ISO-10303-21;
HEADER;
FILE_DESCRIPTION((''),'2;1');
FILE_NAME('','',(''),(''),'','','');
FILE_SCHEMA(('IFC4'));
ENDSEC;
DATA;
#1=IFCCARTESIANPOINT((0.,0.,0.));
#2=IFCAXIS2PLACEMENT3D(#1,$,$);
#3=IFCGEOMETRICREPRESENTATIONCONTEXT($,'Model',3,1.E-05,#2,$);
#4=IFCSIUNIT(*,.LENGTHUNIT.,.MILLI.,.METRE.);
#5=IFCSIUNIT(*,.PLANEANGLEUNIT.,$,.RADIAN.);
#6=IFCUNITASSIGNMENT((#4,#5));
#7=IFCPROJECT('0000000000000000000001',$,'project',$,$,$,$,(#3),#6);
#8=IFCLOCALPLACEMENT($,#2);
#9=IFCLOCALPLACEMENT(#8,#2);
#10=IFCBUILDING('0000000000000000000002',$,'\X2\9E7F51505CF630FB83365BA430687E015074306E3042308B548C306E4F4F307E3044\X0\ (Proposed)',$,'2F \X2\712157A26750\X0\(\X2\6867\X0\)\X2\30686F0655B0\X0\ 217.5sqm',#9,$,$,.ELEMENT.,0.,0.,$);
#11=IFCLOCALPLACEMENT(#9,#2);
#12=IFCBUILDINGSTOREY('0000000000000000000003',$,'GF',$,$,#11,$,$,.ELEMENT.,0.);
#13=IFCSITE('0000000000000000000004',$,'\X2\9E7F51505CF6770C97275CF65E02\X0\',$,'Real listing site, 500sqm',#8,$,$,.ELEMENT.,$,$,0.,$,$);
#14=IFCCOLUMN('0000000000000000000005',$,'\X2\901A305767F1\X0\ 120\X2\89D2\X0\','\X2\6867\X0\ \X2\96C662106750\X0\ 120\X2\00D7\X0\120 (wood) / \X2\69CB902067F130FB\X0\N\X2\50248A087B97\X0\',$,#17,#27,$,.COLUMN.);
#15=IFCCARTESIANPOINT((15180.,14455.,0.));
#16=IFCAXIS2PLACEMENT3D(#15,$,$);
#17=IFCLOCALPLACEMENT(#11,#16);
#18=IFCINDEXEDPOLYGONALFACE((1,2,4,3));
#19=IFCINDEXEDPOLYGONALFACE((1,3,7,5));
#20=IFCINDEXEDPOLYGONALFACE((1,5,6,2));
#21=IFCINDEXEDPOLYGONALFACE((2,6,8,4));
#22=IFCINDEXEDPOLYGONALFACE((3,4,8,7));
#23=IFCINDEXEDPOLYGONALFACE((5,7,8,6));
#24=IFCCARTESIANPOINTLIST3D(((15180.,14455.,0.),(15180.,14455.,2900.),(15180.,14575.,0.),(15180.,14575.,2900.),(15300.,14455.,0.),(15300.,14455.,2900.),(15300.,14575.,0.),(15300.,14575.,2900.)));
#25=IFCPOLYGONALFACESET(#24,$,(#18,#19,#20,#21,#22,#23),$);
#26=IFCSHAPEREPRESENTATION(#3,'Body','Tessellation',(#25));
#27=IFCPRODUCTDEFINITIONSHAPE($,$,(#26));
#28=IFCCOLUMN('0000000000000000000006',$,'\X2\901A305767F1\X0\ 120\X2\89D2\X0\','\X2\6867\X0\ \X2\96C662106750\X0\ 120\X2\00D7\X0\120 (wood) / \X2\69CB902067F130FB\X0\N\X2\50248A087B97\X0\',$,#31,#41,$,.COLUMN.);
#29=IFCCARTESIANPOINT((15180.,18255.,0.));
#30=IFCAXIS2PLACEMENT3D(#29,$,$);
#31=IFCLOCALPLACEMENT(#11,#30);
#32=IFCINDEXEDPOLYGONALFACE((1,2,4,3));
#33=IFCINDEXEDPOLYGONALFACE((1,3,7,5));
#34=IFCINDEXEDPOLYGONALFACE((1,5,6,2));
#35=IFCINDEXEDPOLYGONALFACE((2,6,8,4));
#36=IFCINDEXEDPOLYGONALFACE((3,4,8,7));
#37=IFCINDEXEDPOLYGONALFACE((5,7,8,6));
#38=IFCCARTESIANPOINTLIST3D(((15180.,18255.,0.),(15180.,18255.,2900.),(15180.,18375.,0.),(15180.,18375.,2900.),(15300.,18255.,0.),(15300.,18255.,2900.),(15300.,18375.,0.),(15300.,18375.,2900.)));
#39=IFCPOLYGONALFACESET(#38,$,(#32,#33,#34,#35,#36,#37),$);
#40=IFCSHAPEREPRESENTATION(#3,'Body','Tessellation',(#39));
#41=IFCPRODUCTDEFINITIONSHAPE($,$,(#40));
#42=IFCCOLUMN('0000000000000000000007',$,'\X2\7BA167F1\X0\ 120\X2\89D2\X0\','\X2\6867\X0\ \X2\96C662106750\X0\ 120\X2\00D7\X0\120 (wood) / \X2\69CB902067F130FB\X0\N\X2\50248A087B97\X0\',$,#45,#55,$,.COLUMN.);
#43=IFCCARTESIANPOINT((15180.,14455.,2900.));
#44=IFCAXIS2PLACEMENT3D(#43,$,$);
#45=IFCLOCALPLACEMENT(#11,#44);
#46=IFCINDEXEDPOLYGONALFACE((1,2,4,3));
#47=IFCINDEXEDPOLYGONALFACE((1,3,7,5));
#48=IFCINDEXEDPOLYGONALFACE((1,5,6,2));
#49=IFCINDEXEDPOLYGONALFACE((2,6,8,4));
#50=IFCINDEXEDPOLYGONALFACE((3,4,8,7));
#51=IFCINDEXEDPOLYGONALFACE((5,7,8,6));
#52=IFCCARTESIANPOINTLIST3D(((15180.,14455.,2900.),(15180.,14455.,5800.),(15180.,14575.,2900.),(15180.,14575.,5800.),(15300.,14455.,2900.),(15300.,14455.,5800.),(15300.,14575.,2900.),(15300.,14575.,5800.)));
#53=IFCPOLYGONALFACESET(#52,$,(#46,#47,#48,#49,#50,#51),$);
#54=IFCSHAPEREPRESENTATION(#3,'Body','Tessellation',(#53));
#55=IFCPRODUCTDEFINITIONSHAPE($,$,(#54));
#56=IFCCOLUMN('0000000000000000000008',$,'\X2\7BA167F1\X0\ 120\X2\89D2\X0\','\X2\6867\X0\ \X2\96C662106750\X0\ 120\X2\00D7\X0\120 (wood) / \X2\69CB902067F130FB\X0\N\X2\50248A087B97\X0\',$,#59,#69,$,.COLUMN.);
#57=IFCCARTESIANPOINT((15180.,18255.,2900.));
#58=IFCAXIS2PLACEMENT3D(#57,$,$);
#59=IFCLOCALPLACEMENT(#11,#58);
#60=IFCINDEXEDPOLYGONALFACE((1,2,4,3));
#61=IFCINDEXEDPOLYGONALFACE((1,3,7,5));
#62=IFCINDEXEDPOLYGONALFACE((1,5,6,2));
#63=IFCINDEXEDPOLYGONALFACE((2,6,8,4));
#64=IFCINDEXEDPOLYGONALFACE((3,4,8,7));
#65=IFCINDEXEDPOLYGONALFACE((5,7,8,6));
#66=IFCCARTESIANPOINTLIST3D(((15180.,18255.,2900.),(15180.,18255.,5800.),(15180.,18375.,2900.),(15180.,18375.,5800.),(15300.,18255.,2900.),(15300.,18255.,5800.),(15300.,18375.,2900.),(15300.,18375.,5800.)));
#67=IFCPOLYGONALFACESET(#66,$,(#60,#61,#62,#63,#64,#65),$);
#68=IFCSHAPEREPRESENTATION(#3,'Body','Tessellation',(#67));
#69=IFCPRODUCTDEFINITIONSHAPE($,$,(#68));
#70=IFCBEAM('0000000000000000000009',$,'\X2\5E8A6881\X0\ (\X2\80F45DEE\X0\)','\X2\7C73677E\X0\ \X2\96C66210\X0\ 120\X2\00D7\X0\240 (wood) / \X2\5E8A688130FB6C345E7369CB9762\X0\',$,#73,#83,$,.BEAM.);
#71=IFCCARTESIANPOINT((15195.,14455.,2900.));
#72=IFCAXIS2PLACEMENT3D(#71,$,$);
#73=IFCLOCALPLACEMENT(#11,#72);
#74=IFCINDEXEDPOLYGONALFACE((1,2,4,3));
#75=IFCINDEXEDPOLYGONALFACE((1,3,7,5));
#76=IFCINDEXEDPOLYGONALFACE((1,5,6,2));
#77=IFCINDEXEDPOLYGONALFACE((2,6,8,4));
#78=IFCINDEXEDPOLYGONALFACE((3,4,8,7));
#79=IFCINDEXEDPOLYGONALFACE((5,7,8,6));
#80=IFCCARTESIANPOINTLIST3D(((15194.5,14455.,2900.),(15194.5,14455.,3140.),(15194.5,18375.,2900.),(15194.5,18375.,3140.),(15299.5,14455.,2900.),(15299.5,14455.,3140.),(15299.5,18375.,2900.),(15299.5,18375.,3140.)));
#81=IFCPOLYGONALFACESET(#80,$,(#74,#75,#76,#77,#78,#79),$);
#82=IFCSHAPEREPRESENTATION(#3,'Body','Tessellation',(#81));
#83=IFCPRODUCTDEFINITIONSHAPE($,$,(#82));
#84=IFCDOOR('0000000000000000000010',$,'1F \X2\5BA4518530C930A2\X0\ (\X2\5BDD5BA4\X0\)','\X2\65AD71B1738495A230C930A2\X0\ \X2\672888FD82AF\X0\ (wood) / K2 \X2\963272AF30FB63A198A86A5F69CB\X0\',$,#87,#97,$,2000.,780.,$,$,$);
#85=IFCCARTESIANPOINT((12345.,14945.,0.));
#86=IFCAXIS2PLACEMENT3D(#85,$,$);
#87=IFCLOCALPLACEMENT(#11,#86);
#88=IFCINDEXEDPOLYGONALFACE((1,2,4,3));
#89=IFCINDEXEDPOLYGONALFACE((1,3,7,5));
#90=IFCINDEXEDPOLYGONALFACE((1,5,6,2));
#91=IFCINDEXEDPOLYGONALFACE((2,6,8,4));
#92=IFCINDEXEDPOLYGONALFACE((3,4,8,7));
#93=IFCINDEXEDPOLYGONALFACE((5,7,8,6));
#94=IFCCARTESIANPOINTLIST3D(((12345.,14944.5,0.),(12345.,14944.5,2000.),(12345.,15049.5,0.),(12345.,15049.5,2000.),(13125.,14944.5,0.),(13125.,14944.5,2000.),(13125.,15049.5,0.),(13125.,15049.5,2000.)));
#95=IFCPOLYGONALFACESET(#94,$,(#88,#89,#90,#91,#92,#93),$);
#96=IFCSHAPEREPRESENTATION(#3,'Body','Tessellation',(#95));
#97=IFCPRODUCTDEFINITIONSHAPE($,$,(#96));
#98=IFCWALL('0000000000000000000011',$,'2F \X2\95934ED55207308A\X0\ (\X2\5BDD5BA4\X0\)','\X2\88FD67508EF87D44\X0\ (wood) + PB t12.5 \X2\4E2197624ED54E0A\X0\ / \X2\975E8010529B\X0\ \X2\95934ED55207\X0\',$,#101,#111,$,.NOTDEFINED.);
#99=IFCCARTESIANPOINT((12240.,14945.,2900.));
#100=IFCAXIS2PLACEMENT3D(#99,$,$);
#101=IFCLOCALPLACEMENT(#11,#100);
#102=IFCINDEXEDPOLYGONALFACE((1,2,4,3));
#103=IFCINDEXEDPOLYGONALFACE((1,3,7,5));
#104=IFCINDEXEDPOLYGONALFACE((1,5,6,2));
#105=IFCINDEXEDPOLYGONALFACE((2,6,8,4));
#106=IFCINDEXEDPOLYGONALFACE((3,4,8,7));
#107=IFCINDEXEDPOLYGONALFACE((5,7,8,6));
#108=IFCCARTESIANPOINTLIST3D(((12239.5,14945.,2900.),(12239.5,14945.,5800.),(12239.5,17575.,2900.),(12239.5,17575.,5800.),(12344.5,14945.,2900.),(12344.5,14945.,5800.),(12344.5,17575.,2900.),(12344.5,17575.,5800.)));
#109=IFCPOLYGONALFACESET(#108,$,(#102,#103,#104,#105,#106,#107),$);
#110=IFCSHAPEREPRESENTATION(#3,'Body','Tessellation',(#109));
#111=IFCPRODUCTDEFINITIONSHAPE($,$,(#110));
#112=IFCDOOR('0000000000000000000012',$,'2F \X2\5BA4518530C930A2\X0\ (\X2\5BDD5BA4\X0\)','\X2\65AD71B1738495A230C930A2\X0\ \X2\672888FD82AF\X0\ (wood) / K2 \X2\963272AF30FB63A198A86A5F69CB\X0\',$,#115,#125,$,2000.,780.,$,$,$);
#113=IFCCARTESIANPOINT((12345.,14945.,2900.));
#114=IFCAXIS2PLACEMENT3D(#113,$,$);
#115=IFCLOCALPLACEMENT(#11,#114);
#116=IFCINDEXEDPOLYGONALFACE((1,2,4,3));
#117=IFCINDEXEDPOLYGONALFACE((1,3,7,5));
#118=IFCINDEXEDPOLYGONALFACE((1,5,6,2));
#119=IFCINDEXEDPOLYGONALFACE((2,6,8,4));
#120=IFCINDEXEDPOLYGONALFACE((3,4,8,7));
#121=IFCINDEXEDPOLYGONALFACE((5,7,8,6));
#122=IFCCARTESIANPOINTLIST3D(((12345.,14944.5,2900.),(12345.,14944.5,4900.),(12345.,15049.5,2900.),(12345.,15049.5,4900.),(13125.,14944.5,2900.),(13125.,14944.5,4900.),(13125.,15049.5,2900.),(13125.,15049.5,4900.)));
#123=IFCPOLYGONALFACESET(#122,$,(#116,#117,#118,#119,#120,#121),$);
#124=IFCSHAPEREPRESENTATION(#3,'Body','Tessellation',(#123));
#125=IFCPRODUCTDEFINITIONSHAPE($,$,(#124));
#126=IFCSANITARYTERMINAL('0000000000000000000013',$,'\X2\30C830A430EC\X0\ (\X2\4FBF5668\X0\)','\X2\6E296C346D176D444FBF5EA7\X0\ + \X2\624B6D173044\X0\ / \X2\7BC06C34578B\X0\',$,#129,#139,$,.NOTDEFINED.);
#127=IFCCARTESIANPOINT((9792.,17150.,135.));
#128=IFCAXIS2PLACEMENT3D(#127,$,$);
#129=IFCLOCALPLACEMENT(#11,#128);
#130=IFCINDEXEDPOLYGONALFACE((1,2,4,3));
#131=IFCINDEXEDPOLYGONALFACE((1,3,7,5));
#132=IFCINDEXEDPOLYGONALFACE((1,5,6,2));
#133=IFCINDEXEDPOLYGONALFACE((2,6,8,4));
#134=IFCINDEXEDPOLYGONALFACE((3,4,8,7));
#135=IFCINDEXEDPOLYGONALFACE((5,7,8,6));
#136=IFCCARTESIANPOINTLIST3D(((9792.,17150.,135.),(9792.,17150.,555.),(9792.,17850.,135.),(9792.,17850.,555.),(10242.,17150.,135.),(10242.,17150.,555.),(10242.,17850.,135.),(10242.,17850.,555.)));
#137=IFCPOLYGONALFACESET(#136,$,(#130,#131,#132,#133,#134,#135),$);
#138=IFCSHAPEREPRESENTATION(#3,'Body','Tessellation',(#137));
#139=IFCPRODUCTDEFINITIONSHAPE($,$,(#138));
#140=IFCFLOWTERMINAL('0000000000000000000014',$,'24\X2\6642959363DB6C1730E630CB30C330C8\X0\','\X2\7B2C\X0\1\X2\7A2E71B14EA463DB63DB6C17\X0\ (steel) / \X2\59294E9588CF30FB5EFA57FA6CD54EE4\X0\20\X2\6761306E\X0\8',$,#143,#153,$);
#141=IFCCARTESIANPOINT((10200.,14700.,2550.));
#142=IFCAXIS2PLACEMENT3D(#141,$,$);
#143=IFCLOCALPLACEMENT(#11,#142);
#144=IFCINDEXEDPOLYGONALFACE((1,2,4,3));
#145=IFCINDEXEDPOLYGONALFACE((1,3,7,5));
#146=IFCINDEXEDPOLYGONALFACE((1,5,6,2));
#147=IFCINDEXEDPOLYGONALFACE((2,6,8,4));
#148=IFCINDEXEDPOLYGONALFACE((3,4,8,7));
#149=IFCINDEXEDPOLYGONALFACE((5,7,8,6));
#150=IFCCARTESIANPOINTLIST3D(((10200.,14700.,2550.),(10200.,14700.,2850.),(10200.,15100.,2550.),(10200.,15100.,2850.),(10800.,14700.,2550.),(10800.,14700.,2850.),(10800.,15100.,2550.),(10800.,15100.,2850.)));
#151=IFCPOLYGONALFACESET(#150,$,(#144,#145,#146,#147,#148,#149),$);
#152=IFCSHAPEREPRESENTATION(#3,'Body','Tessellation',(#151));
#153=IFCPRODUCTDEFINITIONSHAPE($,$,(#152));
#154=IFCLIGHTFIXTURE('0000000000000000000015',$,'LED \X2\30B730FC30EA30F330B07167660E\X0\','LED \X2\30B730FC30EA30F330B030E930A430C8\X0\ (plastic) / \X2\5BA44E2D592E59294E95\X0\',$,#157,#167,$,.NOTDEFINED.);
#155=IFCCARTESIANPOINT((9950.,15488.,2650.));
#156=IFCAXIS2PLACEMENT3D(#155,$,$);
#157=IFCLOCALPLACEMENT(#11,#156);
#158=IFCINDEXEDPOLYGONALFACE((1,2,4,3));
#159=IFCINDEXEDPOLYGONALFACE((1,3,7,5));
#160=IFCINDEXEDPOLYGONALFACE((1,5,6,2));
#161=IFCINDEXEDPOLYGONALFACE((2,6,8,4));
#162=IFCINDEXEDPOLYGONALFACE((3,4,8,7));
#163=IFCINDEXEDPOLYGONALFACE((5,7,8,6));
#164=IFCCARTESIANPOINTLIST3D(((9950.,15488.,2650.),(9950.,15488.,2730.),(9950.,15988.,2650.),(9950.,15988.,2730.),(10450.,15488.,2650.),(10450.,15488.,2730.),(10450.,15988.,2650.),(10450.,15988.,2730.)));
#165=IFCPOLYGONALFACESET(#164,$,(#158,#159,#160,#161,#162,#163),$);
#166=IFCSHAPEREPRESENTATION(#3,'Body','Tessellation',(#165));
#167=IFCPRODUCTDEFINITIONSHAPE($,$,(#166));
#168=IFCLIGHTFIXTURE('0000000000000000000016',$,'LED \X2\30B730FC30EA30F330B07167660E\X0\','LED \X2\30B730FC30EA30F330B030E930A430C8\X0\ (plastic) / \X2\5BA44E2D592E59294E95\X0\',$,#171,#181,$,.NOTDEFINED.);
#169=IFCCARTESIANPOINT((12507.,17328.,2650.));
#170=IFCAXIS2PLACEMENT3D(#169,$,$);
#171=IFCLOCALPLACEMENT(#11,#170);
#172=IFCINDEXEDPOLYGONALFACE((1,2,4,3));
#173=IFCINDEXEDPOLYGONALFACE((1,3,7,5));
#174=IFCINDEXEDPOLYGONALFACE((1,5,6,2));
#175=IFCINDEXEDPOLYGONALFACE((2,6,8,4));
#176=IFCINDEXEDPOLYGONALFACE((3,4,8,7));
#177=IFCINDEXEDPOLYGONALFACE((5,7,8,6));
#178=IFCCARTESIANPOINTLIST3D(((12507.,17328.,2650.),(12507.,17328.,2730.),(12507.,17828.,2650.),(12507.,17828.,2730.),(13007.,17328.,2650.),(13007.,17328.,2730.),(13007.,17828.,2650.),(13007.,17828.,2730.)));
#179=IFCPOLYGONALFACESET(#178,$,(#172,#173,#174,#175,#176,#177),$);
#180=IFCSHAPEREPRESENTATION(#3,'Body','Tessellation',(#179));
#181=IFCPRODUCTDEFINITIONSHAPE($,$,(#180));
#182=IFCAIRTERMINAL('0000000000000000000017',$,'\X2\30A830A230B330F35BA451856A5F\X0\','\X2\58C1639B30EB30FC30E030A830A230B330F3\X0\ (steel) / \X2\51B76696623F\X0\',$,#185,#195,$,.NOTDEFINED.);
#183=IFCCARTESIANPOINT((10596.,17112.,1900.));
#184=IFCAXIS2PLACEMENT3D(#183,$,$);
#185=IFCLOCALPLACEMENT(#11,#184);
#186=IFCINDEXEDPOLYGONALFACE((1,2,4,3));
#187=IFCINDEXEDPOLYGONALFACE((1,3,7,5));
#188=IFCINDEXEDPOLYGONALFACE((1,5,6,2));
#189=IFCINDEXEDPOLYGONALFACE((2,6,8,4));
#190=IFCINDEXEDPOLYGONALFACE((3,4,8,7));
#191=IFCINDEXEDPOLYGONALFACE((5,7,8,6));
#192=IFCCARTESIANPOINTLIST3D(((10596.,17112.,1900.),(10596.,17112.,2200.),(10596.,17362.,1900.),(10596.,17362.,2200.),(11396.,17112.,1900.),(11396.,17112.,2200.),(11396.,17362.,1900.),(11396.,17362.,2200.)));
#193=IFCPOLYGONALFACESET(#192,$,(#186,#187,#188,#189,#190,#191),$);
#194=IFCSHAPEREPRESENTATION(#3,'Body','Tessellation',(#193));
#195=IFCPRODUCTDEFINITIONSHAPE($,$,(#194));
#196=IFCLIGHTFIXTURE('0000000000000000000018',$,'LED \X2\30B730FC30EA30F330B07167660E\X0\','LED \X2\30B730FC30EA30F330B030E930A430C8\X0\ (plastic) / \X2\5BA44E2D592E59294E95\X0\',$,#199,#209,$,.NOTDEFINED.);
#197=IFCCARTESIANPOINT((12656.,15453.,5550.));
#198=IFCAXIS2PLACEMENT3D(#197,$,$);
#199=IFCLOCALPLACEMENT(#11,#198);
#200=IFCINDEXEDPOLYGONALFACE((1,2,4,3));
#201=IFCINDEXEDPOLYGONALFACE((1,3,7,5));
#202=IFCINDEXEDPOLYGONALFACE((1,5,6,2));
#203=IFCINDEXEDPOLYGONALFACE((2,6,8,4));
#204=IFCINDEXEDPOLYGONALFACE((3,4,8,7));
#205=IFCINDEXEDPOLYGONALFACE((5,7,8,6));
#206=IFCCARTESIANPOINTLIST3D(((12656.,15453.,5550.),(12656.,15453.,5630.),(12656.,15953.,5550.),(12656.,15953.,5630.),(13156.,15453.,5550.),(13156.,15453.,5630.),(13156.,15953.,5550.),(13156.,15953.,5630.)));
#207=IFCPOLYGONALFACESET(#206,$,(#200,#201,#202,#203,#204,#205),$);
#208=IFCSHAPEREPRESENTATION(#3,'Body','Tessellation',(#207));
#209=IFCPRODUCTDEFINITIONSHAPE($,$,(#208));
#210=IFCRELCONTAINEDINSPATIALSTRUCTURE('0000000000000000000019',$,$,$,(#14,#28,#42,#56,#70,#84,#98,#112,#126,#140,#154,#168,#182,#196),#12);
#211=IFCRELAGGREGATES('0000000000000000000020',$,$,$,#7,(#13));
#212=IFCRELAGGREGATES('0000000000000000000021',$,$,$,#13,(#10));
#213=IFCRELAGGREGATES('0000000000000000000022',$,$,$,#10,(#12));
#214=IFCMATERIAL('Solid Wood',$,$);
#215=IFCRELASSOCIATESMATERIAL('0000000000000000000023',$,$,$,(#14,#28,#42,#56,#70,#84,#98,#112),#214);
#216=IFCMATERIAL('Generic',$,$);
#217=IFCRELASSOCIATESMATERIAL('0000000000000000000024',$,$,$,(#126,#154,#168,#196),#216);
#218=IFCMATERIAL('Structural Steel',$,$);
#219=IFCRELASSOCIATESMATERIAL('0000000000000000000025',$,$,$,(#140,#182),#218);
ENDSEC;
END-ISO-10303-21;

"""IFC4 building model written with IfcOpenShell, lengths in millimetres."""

from ifc_helpers import new_model, si_unit, frame, frame_2d, origin, place, context, project, spatial, rectangle, extrude, material, element, save


model = new_model("IFC4")

# Units and contexts
model_context = context("Model", 3, precision=1e-05, world=origin())
ifc_project = project(units=[si_unit("LENGTHUNIT", "METRE", prefix="MILLI"), si_unit("PLANEANGLEUNIT", "RADIAN")], contexts=[model_context])

# Site, building, storey
site_placement = place(None, origin())
site = spatial("IfcSite", under=ifc_project, at=site_placement, Name="鹿児島県霧島市", ObjectType="Real listing site, 500sqm", CompositionType="ELEMENT", RefElevation=0.0)
building_placement = place(site_placement, origin())
building = spatial("IfcBuilding", under=site, at=building_placement, Name="鹿児島・茶室と縁側のある和の住まい (Proposed)", ObjectType="2F 無垢材(桧)と漆喰 217.5sqm", CompositionType="ELEMENT", ElevationOfRefHeight=0.0, ElevationOfTerrain=0.0)
storey_placement = place(building_placement, origin())
storey = spatial("IfcBuildingStorey", under=building, at=storey_placement, Name="GF", CompositionType="ELEMENT", Elevation=0.0)

# Columns
ifc_material_1 = material(Name="Solid Wood")
column_1_placement = place(storey_placement, frame((15180.0, 14455.0, 0.0)))
element("IfcColumn", 1, at=column_1_placement, inside=storey, material=ifc_material_1, Name="通し柱 120角", Description="桧 集成材 120×120 (wood) / 構造柱・N値計算", PredefinedType="COLUMN", context=model_context, shape_type="SweptSolid", body=[
    extrude(rectangle(XDim=120.0, YDim=120.0, at=frame_2d((60.0, 60.0))), frame((15180.0, 14455.0, 0.0)), (0.0, 0.0, 1.0), 2900.0),
])
column_2_placement = place(storey_placement, frame((15180.0, 18255.0, 0.0)))
element("IfcColumn", 2, at=column_2_placement, inside=storey, material=ifc_material_1, Name="通し柱 120角", Description="桧 集成材 120×120 (wood) / 構造柱・N値計算", PredefinedType="COLUMN", context=model_context, shape_type="SweptSolid", body=[
    extrude(rectangle(XDim=120.0, YDim=120.0, at=frame_2d((60.0, 60.0))), frame((15180.0, 18255.0, 0.0)), (0.0, 0.0, 1.0), 2900.0),
])
column_3_placement = place(storey_placement, frame((15180.0, 14455.0, 2900.0)))
element("IfcColumn", 3, at=column_3_placement, inside=storey, material=ifc_material_1, Name="管柱 120角", Description="桧 集成材 120×120 (wood) / 構造柱・N値計算", PredefinedType="COLUMN", context=model_context, shape_type="SweptSolid", body=[
    extrude(rectangle(XDim=120.0, YDim=120.0, at=frame_2d((60.0, 60.0))), frame((15180.0, 14455.0, 2900.0)), (0.0, 0.0, 1.0), 2900.0),
])
column_4_placement = place(storey_placement, frame((15180.0, 18255.0, 2900.0)))
element("IfcColumn", 4, at=column_4_placement, inside=storey, material=ifc_material_1, Name="管柱 120角", Description="桧 集成材 120×120 (wood) / 構造柱・N値計算", PredefinedType="COLUMN", context=model_context, shape_type="SweptSolid", body=[
    extrude(rectangle(XDim=120.0, YDim=120.0, at=frame_2d((60.0, 60.0))), frame((15180.0, 18255.0, 2900.0)), (0.0, 0.0, 1.0), 2900.0),
])

# Beam
beam_1_placement = place(storey_placement, frame((15195.0, 14455.0, 2900.0)))
element("IfcBeam", 5, at=beam_1_placement, inside=storey, material=ifc_material_1, Name="床梁 (胴差)", Description="米松 集成 120×240 (wood) / 床梁・水平構面", PredefinedType="BEAM", context=model_context, shape_type="SweptSolid", body=[
    extrude(rectangle(XDim=105.0, YDim=3920.0, at=frame_2d((52.0, 1960.0))), frame((15195.0, 14455.0, 2900.0)), (0.0, 0.0, 1.0), 240.0),
])

# Door
door_1_placement = place(storey_placement, frame((12345.0, 14945.0, 0.0)))
element("IfcDoor", 6, at=door_1_placement, inside=storey, material=ifc_material_1, Name="1F 室内ドア (寝室)", Description="断熱玄関ドア 木製芯 (wood) / K2 防犯・採風機構", OverallHeight=2000.0, OverallWidth=780.0, context=model_context, shape_type="SweptSolid", body=[
    extrude(rectangle(XDim=780.0, YDim=105.0, at=frame_2d((390.0, 52.0))), frame((12345.0, 14945.0, 0.0)), (0.0, 0.0, 1.0), 2000.0),
])

# Wall
wall_1_placement = place(storey_placement, frame((12240.0, 14945.0, 2900.0)))
element("IfcWall", 7, at=wall_1_placement, inside=storey, material=ifc_material_1, Name="2F 間仕切り (寝室)", Description="製材軸組 (wood) + PB t12.5 両面仕上 / 非耐力 間仕切", PredefinedType="NOTDEFINED", context=model_context, shape_type="SweptSolid", body=[
    extrude(rectangle(XDim=105.0, YDim=2630.0, at=frame_2d((52.0, 1315.0))), frame((12240.0, 14945.0, 2900.0)), (0.0, 0.0, 1.0), 2900.0),
])

# Door
door_2_placement = place(storey_placement, frame((12345.0, 14945.0, 2900.0)))
element("IfcDoor", 8, at=door_2_placement, inside=storey, material=ifc_material_1, Name="2F 室内ドア (寝室)", Description="断熱玄関ドア 木製芯 (wood) / K2 防犯・採風機構", OverallHeight=2000.0, OverallWidth=780.0, context=model_context, shape_type="SweptSolid", body=[
    extrude(rectangle(XDim=780.0, YDim=105.0, at=frame_2d((390.0, 52.0))), frame((12345.0, 14945.0, 2900.0)), (0.0, 0.0, 1.0), 2000.0),
])

# Sanitary terminal
ifc_material_2 = material(Name="Generic")
sanitary_terminal_placement = place(storey_placement, frame((9792.0, 17150.0, 135.0)))
element("IfcSanitaryTerminal", 9, at=sanitary_terminal_placement, inside=storey, material=ifc_material_2, Name="トイレ (便器)", Description="温水洗浄便座 + 手洗い / 節水型", PredefinedType="NOTDEFINED", context=model_context, shape_type="SweptSolid", body=[
    extrude(rectangle(XDim=450.0, YDim=700.0, at=frame_2d((225.0, 350.0))), frame((9792.0, 17150.0, 135.0)), (0.0, 0.0, 1.0), 420.0),
])

# Flow terminal
ifc_material_3 = material(Name="Structural Steel")
flow_terminal_placement = place(storey_placement, frame((10200.0, 14700.0, 2550.0)))
element("IfcFlowTerminal", 10, at=flow_terminal_placement, inside=storey, material=ifc_material_3, Name="24時間換気ユニット", Description="第1種熱交換換気 (steel) / 天井裏・建基法令20条の8", context=model_context, shape_type="SweptSolid", body=[
    extrude(rectangle(XDim=600.0, YDim=400.0, at=frame_2d((300.0, 200.0))), frame((10200.0, 14700.0, 2550.0)), (0.0, 0.0, 1.0), 300.0),
])

# Light fixtures
light_fixture_1_placement = place(storey_placement, frame((9950.0, 15488.0, 2650.0)))
element("IfcLightFixture", 11, at=light_fixture_1_placement, inside=storey, material=ifc_material_2, Name="LED シーリング照明", Description="LED シーリングライト (plastic) / 室中央天井", PredefinedType="NOTDEFINED", context=model_context, shape_type="SweptSolid", body=[
    extrude(rectangle(XDim=500.0, YDim=500.0, at=frame_2d((250.0, 250.0))), frame((9950.0, 15488.0, 2650.0)), (0.0, 0.0, 1.0), 80.0),
])
light_fixture_2_placement = place(storey_placement, frame((12507.0, 17328.0, 2650.0)))
element("IfcLightFixture", 12, at=light_fixture_2_placement, inside=storey, material=ifc_material_2, Name="LED シーリング照明", Description="LED シーリングライト (plastic) / 室中央天井", PredefinedType="NOTDEFINED", context=model_context, shape_type="SweptSolid", body=[
    extrude(rectangle(XDim=500.0, YDim=500.0, at=frame_2d((250.0, 250.0))), frame((12507.0, 17328.0, 2650.0)), (0.0, 0.0, 1.0), 80.0),
])

# Air terminal
air_terminal_1_placement = place(storey_placement, frame((10596.0, 17112.0, 1900.0)))
element("IfcAirTerminal", 13, at=air_terminal_1_placement, inside=storey, material=ifc_material_3, Name="エアコン室内機", Description="壁掛ルームエアコン (steel) / 冷暖房", PredefinedType="NOTDEFINED", context=model_context, shape_type="SweptSolid", body=[
    extrude(rectangle(XDim=800.0, YDim=250.0, at=frame_2d((400.0, 125.0))), frame((10596.0, 17112.0, 1900.0)), (0.0, 0.0, 1.0), 300.0),
])

# Light fixture
light_fixture_3_placement = place(storey_placement, frame((12656.0, 15453.0, 5550.0)))
element("IfcLightFixture", 14, at=light_fixture_3_placement, inside=storey, material=ifc_material_2, Name="LED シーリング照明", Description="LED シーリングライト (plastic) / 室中央天井", PredefinedType="NOTDEFINED", context=model_context, shape_type="SweptSolid", body=[
    extrude(rectangle(XDim=500.0, YDim=500.0, at=frame_2d((250.0, 250.0))), frame((12656.0, 15453.0, 5550.0)), (0.0, 0.0, 1.0), 80.0),
])

save(model, "model.ifc")
